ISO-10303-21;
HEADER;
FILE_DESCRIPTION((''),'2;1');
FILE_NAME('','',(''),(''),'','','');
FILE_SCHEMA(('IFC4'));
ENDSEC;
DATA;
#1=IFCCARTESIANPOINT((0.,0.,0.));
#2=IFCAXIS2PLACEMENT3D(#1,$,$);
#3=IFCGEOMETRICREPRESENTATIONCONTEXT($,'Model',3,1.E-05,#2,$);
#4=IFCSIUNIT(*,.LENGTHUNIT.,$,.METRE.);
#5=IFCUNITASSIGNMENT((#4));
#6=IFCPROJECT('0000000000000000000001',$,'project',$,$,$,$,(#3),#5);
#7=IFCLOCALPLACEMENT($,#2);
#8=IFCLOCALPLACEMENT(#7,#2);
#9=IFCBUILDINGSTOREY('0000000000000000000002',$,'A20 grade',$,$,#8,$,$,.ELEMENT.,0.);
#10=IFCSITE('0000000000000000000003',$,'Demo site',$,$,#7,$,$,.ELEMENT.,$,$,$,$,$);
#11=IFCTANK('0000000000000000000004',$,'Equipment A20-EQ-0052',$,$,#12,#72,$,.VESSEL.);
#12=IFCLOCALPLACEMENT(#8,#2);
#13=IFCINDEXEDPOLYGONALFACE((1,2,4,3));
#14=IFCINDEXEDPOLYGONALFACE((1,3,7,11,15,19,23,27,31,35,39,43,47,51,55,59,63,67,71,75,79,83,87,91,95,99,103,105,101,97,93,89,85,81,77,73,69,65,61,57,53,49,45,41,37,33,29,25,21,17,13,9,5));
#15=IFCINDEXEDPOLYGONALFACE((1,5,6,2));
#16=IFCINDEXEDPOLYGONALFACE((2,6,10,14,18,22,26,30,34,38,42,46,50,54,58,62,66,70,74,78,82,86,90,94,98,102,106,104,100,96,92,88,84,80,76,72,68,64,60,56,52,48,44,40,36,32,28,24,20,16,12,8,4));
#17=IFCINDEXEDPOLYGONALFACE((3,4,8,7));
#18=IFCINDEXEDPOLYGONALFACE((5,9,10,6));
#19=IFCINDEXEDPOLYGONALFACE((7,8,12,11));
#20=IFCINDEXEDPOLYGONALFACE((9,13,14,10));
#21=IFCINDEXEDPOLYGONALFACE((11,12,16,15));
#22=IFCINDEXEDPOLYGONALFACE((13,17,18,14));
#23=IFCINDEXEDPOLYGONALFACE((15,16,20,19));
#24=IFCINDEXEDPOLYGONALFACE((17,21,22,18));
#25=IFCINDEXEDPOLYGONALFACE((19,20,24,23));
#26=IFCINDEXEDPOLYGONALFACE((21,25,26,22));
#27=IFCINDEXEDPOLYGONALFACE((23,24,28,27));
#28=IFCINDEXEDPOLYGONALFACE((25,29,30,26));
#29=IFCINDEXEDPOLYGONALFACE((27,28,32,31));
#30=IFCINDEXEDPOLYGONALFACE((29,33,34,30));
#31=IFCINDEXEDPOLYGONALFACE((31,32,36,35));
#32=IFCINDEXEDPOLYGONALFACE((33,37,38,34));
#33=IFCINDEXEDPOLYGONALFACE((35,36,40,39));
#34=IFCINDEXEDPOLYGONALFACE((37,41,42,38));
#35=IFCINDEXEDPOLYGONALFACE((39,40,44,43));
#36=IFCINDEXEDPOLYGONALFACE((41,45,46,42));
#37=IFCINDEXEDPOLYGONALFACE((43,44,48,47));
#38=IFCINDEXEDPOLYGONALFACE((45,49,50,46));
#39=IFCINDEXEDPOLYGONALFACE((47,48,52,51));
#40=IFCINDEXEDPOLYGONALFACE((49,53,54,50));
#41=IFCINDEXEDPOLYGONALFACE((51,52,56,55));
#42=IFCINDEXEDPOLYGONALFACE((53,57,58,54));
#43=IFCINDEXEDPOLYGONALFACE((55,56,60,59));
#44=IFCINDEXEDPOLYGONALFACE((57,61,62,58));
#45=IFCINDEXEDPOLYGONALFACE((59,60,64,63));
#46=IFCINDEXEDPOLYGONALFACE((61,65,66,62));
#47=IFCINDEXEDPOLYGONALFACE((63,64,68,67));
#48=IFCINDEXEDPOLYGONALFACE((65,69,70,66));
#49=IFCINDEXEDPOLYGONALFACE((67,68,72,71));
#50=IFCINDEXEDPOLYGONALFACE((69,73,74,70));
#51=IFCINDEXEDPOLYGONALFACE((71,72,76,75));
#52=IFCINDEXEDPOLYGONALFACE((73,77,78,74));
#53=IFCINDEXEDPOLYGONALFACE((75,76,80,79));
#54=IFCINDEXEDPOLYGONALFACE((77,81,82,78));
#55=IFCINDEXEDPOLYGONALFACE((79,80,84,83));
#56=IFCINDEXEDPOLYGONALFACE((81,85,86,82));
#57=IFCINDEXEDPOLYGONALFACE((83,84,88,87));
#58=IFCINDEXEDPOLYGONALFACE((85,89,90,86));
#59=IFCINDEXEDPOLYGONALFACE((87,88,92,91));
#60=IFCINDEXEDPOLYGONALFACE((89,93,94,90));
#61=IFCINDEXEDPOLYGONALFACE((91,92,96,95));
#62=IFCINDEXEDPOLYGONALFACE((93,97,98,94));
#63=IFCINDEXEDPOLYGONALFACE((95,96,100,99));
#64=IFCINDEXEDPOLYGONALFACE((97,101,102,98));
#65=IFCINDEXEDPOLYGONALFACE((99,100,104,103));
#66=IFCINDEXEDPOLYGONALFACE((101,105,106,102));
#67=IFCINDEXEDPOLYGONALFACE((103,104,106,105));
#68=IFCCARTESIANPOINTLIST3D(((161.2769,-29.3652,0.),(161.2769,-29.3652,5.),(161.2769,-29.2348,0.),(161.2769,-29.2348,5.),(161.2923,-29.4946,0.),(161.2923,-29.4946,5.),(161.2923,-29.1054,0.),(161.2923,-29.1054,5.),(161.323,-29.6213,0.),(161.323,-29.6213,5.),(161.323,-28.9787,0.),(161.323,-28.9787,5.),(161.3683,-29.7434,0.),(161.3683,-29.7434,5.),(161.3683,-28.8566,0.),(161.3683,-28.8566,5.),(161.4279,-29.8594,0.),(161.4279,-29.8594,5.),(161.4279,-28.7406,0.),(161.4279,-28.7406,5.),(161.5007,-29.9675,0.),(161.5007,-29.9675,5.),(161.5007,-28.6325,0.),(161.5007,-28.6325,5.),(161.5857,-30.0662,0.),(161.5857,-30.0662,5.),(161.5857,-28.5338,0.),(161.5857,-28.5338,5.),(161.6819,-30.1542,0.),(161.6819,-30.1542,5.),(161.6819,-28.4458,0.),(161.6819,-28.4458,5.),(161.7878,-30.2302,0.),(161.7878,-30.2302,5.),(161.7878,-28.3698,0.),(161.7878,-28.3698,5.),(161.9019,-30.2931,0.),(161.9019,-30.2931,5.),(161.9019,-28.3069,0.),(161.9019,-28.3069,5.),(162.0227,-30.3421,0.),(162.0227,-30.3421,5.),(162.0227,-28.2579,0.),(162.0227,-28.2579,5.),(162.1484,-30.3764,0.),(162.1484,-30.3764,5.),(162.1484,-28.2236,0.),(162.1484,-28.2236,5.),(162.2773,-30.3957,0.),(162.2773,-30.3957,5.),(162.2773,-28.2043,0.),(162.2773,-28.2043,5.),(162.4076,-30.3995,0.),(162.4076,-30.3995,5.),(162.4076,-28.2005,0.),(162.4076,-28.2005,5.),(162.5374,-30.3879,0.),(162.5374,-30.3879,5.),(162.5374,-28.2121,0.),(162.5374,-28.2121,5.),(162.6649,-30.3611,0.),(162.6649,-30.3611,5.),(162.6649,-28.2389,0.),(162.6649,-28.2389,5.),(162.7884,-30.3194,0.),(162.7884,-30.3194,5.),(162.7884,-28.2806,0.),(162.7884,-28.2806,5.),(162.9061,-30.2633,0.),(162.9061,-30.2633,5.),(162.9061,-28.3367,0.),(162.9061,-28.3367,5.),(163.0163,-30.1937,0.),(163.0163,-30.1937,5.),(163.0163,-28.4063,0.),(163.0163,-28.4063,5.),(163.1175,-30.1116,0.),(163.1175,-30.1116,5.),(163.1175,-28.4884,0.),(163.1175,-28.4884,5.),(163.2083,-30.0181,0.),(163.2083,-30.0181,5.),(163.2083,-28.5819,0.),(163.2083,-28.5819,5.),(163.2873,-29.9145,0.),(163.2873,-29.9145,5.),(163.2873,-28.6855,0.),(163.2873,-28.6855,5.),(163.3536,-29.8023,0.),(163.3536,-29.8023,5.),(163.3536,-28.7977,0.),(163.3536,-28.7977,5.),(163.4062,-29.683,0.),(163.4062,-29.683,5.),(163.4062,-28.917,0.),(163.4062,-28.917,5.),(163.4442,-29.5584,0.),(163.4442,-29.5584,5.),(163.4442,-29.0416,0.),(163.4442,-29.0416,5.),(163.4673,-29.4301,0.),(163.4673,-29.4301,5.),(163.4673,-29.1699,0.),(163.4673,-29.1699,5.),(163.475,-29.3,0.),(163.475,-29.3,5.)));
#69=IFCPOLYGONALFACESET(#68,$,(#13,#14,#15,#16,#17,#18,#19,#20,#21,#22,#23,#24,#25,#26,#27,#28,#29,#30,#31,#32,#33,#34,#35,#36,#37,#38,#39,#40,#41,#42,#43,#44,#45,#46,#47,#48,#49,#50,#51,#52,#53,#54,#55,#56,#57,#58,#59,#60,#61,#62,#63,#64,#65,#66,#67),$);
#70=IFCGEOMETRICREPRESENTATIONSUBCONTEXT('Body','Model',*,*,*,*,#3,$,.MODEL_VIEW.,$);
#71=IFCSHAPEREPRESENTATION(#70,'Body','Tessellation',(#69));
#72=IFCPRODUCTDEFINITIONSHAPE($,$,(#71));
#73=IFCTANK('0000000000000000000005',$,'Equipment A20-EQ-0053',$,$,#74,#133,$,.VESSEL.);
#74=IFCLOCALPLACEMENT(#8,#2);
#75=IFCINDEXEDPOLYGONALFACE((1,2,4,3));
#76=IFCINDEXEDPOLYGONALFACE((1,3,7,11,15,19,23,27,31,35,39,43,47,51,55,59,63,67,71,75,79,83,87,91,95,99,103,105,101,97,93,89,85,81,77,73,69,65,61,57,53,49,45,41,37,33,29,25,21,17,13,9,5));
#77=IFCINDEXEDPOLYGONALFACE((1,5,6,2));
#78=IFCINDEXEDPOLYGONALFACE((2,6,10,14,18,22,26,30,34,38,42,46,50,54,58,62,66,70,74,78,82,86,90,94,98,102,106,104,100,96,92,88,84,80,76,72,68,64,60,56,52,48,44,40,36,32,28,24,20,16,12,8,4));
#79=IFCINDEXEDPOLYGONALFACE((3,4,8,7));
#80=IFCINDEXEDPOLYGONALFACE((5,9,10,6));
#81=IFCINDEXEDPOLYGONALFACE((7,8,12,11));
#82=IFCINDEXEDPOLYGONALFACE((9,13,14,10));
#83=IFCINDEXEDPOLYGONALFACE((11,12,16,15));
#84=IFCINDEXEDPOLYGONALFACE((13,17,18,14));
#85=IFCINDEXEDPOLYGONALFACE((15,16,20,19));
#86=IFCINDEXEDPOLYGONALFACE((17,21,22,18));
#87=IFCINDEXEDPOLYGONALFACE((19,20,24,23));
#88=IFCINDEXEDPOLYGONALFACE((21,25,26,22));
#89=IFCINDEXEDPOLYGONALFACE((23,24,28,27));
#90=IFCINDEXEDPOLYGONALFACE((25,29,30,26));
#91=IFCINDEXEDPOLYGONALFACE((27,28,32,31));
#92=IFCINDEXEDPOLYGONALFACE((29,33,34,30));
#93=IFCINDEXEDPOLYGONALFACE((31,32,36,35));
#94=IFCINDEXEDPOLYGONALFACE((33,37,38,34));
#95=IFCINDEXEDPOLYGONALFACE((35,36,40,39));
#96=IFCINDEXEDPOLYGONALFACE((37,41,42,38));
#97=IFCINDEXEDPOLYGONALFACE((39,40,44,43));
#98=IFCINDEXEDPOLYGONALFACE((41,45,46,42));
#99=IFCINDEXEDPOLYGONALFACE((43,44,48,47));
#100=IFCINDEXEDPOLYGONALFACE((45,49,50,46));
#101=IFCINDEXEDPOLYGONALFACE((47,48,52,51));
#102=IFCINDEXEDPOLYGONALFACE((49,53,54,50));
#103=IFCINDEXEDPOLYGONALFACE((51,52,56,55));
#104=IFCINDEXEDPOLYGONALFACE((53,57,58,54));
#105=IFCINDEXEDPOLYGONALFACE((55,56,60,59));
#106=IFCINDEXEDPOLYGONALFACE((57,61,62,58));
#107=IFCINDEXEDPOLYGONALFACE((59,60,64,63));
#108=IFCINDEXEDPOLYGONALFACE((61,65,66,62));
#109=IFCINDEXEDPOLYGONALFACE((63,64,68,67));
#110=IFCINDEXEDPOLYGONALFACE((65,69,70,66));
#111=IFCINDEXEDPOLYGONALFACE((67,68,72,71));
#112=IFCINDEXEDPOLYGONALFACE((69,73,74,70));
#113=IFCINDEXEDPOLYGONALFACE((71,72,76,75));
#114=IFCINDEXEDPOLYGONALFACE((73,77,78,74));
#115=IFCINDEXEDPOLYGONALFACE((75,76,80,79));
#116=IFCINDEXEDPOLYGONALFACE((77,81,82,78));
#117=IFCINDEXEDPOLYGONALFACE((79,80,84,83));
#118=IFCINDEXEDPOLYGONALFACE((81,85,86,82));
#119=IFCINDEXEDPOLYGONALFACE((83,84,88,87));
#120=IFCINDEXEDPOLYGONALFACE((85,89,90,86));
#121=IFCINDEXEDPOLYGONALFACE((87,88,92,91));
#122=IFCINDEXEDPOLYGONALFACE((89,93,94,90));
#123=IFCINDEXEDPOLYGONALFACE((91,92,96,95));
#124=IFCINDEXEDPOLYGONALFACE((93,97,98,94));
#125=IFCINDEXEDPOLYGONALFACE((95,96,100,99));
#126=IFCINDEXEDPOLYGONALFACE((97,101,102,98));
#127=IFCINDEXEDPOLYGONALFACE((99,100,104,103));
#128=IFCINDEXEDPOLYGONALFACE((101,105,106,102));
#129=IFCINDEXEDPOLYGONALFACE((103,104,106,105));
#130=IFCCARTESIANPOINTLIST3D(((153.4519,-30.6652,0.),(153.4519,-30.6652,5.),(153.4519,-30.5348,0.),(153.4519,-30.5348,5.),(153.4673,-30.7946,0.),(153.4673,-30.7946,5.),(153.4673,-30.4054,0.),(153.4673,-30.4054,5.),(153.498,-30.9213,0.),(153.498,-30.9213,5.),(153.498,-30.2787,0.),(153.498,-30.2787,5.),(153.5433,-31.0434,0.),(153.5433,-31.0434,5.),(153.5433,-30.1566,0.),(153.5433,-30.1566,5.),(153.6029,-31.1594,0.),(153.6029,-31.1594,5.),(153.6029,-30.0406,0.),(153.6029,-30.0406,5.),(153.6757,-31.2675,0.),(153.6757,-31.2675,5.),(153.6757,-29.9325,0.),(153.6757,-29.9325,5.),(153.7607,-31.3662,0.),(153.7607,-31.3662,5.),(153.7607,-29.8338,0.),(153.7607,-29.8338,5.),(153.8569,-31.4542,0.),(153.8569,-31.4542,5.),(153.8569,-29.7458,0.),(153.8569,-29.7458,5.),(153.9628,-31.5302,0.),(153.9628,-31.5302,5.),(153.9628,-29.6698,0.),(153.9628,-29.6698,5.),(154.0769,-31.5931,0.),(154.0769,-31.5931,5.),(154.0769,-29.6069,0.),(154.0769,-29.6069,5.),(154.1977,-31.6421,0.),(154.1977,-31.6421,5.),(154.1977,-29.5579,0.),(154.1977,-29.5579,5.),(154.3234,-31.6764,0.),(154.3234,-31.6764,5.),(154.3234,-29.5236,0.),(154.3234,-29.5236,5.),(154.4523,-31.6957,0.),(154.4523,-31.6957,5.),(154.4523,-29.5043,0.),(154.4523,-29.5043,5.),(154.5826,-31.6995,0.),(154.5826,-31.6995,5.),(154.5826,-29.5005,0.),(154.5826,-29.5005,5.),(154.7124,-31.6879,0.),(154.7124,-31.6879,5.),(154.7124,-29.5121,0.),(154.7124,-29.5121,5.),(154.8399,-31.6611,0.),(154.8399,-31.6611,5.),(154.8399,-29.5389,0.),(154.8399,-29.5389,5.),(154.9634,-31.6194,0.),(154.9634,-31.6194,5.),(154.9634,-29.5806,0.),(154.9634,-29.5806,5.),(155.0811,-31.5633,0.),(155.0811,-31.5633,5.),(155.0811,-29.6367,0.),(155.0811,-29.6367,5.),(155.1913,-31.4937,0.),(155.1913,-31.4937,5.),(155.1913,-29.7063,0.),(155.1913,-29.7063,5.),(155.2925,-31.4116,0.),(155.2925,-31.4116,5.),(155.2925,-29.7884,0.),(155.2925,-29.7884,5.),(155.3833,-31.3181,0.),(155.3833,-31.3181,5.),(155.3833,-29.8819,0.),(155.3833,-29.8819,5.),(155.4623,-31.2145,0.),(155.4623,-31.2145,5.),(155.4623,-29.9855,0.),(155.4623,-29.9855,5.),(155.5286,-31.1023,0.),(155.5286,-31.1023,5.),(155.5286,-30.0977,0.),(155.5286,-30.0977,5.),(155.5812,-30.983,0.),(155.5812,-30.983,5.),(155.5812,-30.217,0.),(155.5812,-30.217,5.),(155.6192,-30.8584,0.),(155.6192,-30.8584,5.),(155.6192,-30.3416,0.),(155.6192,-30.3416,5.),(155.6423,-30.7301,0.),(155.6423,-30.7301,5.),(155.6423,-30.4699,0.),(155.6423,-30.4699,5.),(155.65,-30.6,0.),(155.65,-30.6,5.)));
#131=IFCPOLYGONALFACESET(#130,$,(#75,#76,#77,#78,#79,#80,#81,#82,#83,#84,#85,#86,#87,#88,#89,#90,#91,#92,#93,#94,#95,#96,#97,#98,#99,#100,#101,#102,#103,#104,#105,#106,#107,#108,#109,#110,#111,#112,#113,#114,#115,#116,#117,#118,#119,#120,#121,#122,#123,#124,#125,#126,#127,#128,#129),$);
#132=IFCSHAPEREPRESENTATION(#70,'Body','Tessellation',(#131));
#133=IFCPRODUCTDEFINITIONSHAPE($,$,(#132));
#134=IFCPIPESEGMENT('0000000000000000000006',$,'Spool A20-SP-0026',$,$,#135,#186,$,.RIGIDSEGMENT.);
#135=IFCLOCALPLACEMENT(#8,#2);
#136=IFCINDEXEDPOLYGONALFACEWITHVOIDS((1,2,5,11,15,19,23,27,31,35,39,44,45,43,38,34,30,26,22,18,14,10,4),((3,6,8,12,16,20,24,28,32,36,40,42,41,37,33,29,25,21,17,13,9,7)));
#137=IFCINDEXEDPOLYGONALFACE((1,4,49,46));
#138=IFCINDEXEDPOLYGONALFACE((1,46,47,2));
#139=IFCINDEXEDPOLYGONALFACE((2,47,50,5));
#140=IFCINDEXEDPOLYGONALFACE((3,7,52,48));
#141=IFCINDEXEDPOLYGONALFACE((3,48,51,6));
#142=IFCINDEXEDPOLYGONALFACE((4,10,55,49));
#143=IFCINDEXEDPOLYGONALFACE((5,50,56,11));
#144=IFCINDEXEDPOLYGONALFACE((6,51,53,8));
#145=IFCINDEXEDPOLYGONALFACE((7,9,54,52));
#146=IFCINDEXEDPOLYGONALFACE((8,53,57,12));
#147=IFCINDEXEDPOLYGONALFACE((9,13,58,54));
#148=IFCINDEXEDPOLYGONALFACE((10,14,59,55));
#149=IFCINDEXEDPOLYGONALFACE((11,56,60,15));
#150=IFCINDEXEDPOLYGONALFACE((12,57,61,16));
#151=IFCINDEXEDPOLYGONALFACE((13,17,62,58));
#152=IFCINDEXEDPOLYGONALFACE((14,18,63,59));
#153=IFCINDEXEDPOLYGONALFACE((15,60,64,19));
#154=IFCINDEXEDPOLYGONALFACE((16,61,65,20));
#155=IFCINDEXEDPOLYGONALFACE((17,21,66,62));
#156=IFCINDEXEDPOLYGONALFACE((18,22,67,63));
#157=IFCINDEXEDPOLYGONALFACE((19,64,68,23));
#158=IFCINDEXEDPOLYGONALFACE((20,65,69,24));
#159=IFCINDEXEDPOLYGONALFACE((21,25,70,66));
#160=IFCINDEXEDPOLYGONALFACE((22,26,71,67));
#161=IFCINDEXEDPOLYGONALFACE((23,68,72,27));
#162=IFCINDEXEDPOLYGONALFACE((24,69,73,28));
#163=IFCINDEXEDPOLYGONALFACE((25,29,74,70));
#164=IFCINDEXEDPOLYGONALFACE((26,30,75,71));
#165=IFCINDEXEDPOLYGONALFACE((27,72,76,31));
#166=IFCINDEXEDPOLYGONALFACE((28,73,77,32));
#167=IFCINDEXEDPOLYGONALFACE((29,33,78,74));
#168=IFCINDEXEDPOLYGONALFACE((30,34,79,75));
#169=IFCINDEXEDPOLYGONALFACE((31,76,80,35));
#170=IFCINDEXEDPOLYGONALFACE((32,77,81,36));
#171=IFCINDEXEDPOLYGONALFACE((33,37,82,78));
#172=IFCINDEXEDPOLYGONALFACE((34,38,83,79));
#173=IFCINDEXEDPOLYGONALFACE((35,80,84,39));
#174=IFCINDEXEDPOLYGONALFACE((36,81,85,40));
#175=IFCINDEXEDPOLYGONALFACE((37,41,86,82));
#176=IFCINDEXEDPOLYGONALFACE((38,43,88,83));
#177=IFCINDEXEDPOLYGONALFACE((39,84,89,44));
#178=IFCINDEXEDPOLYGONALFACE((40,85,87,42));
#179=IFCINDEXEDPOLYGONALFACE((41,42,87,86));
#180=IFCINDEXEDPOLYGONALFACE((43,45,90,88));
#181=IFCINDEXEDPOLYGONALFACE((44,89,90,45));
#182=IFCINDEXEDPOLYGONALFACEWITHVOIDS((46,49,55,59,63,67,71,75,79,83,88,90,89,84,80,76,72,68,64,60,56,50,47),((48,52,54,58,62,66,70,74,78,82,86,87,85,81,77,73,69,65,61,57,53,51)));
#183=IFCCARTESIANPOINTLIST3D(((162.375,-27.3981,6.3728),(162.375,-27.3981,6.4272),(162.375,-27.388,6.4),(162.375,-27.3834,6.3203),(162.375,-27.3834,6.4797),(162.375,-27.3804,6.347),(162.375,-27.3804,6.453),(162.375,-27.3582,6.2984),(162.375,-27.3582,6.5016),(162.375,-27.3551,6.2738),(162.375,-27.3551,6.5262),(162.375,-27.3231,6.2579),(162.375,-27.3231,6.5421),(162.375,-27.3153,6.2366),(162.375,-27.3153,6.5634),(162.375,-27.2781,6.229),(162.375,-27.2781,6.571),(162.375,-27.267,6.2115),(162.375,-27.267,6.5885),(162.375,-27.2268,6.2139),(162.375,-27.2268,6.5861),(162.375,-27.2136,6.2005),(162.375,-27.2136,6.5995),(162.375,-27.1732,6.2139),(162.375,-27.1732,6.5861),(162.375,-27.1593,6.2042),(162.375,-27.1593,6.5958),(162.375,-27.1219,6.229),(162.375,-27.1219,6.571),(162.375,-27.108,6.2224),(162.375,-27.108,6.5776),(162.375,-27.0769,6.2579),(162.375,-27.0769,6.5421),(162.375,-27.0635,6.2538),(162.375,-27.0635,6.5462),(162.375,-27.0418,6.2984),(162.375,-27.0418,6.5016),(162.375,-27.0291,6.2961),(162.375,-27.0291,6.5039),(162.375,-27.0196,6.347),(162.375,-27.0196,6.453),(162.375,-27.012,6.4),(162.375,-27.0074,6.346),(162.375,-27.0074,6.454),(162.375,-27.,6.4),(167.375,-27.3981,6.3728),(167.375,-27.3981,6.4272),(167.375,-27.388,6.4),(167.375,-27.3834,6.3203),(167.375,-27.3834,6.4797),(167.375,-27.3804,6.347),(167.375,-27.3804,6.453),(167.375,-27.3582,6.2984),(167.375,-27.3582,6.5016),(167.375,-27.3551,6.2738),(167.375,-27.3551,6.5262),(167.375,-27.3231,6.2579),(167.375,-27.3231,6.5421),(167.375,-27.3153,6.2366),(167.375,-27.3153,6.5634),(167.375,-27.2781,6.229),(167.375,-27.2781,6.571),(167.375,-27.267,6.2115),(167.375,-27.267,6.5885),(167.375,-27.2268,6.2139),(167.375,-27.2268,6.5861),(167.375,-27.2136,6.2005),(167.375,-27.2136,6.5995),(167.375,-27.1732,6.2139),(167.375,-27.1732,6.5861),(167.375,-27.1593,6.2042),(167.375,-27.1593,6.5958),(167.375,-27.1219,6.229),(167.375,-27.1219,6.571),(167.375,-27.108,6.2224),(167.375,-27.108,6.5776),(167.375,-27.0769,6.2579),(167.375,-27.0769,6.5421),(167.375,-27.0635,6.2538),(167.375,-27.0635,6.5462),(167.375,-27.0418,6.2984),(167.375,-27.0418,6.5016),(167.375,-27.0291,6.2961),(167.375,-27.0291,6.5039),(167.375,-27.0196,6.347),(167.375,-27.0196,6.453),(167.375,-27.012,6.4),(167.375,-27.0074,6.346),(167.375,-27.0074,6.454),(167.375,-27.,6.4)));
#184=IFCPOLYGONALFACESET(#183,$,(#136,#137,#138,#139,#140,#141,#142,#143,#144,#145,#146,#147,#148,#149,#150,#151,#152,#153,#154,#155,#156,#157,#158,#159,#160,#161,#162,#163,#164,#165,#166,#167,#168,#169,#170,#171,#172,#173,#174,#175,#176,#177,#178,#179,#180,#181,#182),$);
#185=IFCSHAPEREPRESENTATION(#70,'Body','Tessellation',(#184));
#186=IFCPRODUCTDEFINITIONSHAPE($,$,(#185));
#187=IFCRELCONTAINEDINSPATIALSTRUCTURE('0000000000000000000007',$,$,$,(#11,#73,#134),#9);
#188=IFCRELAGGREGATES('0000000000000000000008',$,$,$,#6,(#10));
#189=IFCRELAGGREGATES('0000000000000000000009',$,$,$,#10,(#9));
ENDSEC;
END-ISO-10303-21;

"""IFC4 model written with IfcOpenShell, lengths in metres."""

from ifc_helpers import new_model, si_unit, frame, origin, place, context, subcontext, project, spatial, circle, hollow_circle, extrude, element, save


model = new_model("IFC4")

# Units and contexts
model_context = context("Model", 3, precision=1e-05, world=origin())
body_context = subcontext(model_context, "Body", "Model", "MODEL_VIEW")
ifc_project = project(units=[si_unit("LENGTHUNIT", "METRE")], contexts=[model_context])

# Site, storey
site_placement = place(None, origin())
site = spatial("IfcSite", under=ifc_project, at=site_placement, Name="Demo site", CompositionType="ELEMENT")
storey_placement = place(site_placement, origin())
storey = spatial("IfcBuildingStorey", under=site, at=storey_placement, Name="A20 grade", CompositionType="ELEMENT", Elevation=0.0)

# Tanks
for number, where, name in (
    (1, (162.375, -29.3, 0.0), "Equipment A20-EQ-0052"),
    (2, (154.55, -30.6, 0.0), "Equipment A20-EQ-0053"),
):
    element("IfcTank", number, at=place(storey_placement, frame(where)), inside=storey, Name=name, PredefinedType="VESSEL", context=body_context, shape_type="SweptSolid", body=[
        extrude(circle(Radius=1.1), origin(), (0.0, 0.0, 1.0), 5.0),
    ])

# Pipe segment
for number, where, name in (
    (3, (162.375, -27.2, 6.4), "Spool A20-SP-0026"),
):
    element("IfcPipeSegment", number, at=place(storey_placement, frame(where)), inside=storey, Name=name, PredefinedType="RIGIDSEGMENT", context=body_context, shape_type="SweptSolid", body=[
        extrude(hollow_circle(Radius=0.2, WallThickness=0.012), frame((0.0, 0.0, 0.0), z_axis=(1.0, 0.0, 0.0), x_axis=(0.0, 1.0, 0.0)), (0.0, 0.0, 1.0), 5.0),
    ])

save(model, "model.ifc")
